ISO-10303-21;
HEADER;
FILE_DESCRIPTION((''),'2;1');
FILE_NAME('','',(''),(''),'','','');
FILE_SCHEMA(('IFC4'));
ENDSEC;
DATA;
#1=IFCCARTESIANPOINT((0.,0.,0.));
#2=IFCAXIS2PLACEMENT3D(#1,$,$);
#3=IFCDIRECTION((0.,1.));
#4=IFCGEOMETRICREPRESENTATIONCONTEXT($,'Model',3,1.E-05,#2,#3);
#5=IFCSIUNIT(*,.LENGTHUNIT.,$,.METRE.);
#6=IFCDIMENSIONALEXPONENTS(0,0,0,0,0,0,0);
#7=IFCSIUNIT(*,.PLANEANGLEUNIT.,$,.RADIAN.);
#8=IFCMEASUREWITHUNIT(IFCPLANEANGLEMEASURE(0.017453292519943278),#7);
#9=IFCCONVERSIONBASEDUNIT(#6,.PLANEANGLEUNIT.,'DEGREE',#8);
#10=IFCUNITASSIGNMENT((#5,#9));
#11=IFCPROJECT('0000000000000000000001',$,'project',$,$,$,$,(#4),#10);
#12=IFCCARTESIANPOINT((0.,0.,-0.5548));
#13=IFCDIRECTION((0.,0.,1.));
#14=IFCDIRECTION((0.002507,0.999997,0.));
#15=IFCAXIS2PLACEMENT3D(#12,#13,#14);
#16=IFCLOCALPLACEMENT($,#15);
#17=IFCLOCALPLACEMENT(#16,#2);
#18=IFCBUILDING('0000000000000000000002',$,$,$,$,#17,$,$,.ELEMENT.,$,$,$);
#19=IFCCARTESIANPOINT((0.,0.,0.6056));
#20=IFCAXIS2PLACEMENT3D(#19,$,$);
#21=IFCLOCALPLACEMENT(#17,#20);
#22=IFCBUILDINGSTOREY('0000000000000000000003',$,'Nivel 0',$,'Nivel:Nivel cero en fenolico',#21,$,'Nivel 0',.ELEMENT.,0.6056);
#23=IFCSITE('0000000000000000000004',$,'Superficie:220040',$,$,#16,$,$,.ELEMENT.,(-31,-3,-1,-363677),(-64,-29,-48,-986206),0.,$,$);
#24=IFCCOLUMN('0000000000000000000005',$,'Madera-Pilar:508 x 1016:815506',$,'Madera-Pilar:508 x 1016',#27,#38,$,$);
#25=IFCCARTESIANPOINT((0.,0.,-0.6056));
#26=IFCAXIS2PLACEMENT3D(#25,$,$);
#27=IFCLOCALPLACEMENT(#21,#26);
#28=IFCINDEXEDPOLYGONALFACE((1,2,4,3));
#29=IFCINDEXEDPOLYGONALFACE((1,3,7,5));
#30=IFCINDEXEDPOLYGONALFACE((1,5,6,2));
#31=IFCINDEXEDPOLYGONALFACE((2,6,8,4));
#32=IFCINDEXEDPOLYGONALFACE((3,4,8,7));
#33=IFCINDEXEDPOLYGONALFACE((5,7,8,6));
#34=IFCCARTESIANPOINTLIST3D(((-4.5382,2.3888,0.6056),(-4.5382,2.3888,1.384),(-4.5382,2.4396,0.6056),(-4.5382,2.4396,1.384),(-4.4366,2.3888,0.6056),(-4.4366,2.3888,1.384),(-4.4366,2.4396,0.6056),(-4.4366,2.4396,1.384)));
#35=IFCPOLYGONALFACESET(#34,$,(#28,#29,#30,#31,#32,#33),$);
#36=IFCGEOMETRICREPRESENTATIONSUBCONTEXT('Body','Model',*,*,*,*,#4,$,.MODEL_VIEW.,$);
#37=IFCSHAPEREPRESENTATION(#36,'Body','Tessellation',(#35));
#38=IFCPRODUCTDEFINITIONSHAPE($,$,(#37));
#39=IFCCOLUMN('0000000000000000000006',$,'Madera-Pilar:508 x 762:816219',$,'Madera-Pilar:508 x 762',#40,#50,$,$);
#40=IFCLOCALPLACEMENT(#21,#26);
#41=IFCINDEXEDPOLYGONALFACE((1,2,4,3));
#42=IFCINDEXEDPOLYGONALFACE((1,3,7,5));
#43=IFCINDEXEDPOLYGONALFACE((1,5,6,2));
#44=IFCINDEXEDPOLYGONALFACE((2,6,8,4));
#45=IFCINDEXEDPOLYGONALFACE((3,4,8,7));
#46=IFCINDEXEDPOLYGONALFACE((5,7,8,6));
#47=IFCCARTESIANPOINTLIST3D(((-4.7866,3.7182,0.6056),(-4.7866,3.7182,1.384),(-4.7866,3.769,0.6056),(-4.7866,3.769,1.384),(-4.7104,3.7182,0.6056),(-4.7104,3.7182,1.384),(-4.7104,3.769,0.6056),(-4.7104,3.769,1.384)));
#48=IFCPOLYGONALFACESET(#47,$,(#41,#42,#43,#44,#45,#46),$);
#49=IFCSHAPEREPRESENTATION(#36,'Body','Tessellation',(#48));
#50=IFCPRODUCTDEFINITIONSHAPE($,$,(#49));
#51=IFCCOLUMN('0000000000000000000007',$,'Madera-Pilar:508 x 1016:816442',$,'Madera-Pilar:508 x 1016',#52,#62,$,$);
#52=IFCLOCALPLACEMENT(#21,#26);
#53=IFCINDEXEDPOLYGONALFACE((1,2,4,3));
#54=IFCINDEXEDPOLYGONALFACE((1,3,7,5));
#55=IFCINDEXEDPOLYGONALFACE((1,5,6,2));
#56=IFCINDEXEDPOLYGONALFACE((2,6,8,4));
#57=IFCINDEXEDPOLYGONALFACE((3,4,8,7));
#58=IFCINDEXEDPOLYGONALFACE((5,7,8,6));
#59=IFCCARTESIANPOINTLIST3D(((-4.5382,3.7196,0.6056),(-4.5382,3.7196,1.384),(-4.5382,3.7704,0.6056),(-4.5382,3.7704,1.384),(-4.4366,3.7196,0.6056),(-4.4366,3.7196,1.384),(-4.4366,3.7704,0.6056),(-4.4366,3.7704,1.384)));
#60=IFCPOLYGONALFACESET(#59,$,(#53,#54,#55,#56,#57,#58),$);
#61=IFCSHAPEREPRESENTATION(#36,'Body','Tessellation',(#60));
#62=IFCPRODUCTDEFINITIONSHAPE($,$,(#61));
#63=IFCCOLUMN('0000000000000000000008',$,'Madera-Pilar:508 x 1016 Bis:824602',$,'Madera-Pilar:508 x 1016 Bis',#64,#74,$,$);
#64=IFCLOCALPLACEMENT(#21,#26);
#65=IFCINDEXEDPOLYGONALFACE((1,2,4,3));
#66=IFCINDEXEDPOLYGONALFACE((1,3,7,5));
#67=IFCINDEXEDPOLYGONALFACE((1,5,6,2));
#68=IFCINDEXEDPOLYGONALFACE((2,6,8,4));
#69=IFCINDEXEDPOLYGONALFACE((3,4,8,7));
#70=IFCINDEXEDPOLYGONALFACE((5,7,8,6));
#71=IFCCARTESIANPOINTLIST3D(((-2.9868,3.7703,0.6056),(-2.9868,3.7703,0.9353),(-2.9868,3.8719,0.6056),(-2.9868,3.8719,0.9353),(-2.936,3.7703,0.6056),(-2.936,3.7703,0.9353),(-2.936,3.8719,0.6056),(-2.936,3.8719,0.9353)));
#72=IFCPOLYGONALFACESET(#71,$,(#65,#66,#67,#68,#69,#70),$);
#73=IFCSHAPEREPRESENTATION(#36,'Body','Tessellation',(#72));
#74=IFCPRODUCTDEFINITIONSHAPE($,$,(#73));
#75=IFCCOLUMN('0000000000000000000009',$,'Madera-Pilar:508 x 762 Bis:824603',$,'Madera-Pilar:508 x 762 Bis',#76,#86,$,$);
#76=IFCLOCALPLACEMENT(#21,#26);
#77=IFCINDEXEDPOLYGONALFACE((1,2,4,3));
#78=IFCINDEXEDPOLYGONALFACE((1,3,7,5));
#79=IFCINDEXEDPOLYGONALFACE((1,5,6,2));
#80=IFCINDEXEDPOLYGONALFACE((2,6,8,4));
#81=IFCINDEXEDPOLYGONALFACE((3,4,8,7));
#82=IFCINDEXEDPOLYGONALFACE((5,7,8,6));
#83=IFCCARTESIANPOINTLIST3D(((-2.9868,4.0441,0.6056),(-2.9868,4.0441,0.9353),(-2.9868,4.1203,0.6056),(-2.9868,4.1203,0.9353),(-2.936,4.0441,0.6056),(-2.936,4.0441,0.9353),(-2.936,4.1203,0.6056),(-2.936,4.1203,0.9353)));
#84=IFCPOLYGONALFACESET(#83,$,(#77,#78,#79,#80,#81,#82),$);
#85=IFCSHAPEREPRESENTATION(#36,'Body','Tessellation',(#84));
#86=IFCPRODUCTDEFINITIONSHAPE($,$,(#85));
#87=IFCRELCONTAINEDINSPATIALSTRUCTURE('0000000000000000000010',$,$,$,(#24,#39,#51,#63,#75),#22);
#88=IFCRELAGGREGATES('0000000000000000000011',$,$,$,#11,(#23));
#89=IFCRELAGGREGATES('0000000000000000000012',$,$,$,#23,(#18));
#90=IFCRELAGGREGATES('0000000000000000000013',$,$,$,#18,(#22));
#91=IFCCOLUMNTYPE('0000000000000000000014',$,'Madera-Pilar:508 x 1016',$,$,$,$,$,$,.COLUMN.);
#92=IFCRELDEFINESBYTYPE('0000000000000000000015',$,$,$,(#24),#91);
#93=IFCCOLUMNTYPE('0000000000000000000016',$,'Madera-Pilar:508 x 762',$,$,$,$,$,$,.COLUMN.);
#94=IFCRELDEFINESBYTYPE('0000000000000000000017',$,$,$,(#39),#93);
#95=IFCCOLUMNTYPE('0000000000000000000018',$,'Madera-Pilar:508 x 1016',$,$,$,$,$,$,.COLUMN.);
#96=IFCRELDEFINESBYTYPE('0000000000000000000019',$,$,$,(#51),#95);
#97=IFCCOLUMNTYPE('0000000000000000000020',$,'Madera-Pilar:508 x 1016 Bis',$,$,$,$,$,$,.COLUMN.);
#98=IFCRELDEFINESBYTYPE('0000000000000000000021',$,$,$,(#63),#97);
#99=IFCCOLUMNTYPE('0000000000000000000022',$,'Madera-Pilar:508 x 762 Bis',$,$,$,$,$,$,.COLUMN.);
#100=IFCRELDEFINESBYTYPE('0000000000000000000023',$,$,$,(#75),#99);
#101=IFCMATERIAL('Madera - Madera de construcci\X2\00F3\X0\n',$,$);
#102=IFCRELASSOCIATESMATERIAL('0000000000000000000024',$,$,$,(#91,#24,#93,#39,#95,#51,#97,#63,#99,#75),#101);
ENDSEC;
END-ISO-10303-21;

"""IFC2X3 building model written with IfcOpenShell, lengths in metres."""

from ifc_helpers import new_model, entity, si_unit, converted_unit, direction, frame, frame_2d, origin, place, context, subcontext, project, spatial, rectangle, extrude, source, transform, mapped, material, type_object, type_shapes, element, save


model = new_model("IFC2X3")

# Units and contexts
model_context = context("Model", 3, precision=1e-05, world=origin(), true_north=direction((0.0, 1.0)))
body_context = subcontext(model_context, "Body", "Model", "MODEL_VIEW")
ifc_project = project(units=[si_unit("LENGTHUNIT", "METRE"), converted_unit("PLANEANGLEUNIT", "DEGREE", entity("IfcPlaneAngleMeasure", 0.017453292519943278), si_unit("PLANEANGLEUNIT", "RADIAN"), dimensions=[0, 0, 0, 0, 0, 0, 0])], contexts=[model_context])

# Site, building, storey
site_placement = place(None, frame((0.0, 0.0, -0.5548), z_axis=(0.0, 0.0, 1.0), x_axis=(0.002507, 0.999997, 0.0)))
site = spatial("IfcSite", under=ifc_project, at=site_placement, Name="Superficie:220040", CompositionType="ELEMENT", RefLatitude=(-31, -3, -1, -363677), RefLongitude=(-64, -29, -48, -986206), RefElevation=0.0)
building_placement = place(site_placement, origin())
building = spatial("IfcBuilding", under=site, at=building_placement, CompositionType="ELEMENT")
storey_placement = place(building_placement, frame((0.0, 0.0, 0.6056)))
storey = spatial("IfcBuildingStorey", under=building, at=storey_placement, Name="Nivel 0", ObjectType="Nivel:Nivel cero en fenolico", LongName="Nivel 0", CompositionType="ELEMENT", Elevation=0.6056)

# Columns
ifc_material = material(Name="Madera - Madera de construcción")
column_type_1 = type_object("IfcColumnType", Name="Madera-Pilar:508 x 1016", PredefinedType="COLUMN", material=ifc_material)
shared_shape_1 = source(origin(), body_context, "Body", "SweptSolid", [
    extrude(rectangle(XDim=0.1016, YDim=0.0508, at=frame_2d((0.0, 0.0), x_axis=(1.0, 0.0))), frame((-4.4874, 2.4142, 0.6056), z_axis=(0.0, 0.0, 1.0), x_axis=(-1.0, 0.0, 0.0)), (0.0, 0.0, 1.0), 0.7784),
])
type_shapes(column_type_1, [shared_shape_1])
column_1_placement = place(storey_placement, frame((0.0, 0.0, -0.6056)))
element("IfcColumn", 1, at=column_1_placement, inside=storey, type_object=column_type_1, material=ifc_material, Name="Madera-Pilar:508 x 1016:815506", ObjectType="Madera-Pilar:508 x 1016", context=body_context, shape_type="MappedRepresentation", body=[
    mapped(shared_shape_1, transform((0.0, 0.0, 0.0), scale=1.0)),
])
column_type_2 = type_object("IfcColumnType", Name="Madera-Pilar:508 x 762", PredefinedType="COLUMN", material=ifc_material)
shared_shape_2 = source(origin(), body_context, "Body", "SweptSolid", [
    extrude(rectangle(XDim=0.0762, YDim=0.0508, at=frame_2d((0.0, 0.0), x_axis=(1.0, 0.0))), frame((-4.7485, 3.7436, 0.6056), z_axis=(0.0, 0.0, 1.0), x_axis=(-1.0, 0.0, 0.0)), (0.0, 0.0, 1.0), 0.7784),
])
type_shapes(column_type_2, [shared_shape_2])
column_2_placement = place(storey_placement, frame((0.0, 0.0, -0.6056)))
element("IfcColumn", 2, at=column_2_placement, inside=storey, type_object=column_type_2, material=ifc_material, Name="Madera-Pilar:508 x 762:816219", ObjectType="Madera-Pilar:508 x 762", context=body_context, shape_type="MappedRepresentation", body=[
    mapped(shared_shape_2, transform((0.0, 0.0, 0.0), scale=1.0)),
])
column_type_3 = type_object("IfcColumnType", Name="Madera-Pilar:508 x 1016", PredefinedType="COLUMN", material=ifc_material)
shared_shape_3 = source(origin(), body_context, "Body", "SweptSolid", [
    extrude(rectangle(XDim=0.1016, YDim=0.0508, at=frame_2d((0.0, 0.0), x_axis=(1.0, 0.0))), frame((-4.4874, 3.745, 0.6056), z_axis=(0.0, 0.0, 1.0), x_axis=(-1.0, 0.0, 0.0)), (0.0, 0.0, 1.0), 0.7784),
])
type_shapes(column_type_3, [shared_shape_3])
column_3_placement = place(storey_placement, frame((0.0, 0.0, -0.6056)))
element("IfcColumn", 3, at=column_3_placement, inside=storey, type_object=column_type_3, material=ifc_material, Name="Madera-Pilar:508 x 1016:816442", ObjectType="Madera-Pilar:508 x 1016", context=body_context, shape_type="MappedRepresentation", body=[
    mapped(shared_shape_3, transform((0.0, 0.0, 0.0), scale=1.0)),
])
column_type_4 = type_object("IfcColumnType", Name="Madera-Pilar:508 x 1016 Bis", PredefinedType="COLUMN", material=ifc_material)
shared_shape_4 = source(origin(), body_context, "Body", "SweptSolid", [
    extrude(rectangle(XDim=0.0508, YDim=0.1016, at=frame_2d((0.0, 0.0), x_axis=(1.0, 0.0))), frame((-2.9614, 3.8211, 0.6056), z_axis=(0.0, 0.0, 1.0), x_axis=(-1.0, 0.0, 0.0)), (0.0, 0.0, 1.0), 0.3297),
])
type_shapes(column_type_4, [shared_shape_4])
column_4_placement = place(storey_placement, frame((0.0, 0.0, -0.6056)))
element("IfcColumn", 4, at=column_4_placement, inside=storey, type_object=column_type_4, material=ifc_material, Name="Madera-Pilar:508 x 1016 Bis:824602", ObjectType="Madera-Pilar:508 x 1016 Bis", context=body_context, shape_type="MappedRepresentation", body=[
    mapped(shared_shape_4, transform((0.0, 0.0, 0.0), scale=1.0)),
])
column_type_5 = type_object("IfcColumnType", Name="Madera-Pilar:508 x 762 Bis", PredefinedType="COLUMN", material=ifc_material)
shared_shape_5 = source(origin(), body_context, "Body", "SweptSolid", [
    extrude(rectangle(XDim=0.0508, YDim=0.0762, at=frame_2d((0.0, 0.0), x_axis=(1.0, 0.0))), frame((-2.9614, 4.0822, 0.6056), z_axis=(0.0, 0.0, 1.0), x_axis=(-1.0, 0.0, 0.0)), (0.0, 0.0, 1.0), 0.3297),
])
type_shapes(column_type_5, [shared_shape_5])
column_5_placement = place(storey_placement, frame((0.0, 0.0, -0.6056)))
element("IfcColumn", 5, at=column_5_placement, inside=storey, type_object=column_type_5, material=ifc_material, Name="Madera-Pilar:508 x 762 Bis:824603", ObjectType="Madera-Pilar:508 x 762 Bis", context=body_context, shape_type="MappedRepresentation", body=[
    mapped(shared_shape_5, transform((0.0, 0.0, 0.0), scale=1.0)),
])

save(model, "model.ifc")
